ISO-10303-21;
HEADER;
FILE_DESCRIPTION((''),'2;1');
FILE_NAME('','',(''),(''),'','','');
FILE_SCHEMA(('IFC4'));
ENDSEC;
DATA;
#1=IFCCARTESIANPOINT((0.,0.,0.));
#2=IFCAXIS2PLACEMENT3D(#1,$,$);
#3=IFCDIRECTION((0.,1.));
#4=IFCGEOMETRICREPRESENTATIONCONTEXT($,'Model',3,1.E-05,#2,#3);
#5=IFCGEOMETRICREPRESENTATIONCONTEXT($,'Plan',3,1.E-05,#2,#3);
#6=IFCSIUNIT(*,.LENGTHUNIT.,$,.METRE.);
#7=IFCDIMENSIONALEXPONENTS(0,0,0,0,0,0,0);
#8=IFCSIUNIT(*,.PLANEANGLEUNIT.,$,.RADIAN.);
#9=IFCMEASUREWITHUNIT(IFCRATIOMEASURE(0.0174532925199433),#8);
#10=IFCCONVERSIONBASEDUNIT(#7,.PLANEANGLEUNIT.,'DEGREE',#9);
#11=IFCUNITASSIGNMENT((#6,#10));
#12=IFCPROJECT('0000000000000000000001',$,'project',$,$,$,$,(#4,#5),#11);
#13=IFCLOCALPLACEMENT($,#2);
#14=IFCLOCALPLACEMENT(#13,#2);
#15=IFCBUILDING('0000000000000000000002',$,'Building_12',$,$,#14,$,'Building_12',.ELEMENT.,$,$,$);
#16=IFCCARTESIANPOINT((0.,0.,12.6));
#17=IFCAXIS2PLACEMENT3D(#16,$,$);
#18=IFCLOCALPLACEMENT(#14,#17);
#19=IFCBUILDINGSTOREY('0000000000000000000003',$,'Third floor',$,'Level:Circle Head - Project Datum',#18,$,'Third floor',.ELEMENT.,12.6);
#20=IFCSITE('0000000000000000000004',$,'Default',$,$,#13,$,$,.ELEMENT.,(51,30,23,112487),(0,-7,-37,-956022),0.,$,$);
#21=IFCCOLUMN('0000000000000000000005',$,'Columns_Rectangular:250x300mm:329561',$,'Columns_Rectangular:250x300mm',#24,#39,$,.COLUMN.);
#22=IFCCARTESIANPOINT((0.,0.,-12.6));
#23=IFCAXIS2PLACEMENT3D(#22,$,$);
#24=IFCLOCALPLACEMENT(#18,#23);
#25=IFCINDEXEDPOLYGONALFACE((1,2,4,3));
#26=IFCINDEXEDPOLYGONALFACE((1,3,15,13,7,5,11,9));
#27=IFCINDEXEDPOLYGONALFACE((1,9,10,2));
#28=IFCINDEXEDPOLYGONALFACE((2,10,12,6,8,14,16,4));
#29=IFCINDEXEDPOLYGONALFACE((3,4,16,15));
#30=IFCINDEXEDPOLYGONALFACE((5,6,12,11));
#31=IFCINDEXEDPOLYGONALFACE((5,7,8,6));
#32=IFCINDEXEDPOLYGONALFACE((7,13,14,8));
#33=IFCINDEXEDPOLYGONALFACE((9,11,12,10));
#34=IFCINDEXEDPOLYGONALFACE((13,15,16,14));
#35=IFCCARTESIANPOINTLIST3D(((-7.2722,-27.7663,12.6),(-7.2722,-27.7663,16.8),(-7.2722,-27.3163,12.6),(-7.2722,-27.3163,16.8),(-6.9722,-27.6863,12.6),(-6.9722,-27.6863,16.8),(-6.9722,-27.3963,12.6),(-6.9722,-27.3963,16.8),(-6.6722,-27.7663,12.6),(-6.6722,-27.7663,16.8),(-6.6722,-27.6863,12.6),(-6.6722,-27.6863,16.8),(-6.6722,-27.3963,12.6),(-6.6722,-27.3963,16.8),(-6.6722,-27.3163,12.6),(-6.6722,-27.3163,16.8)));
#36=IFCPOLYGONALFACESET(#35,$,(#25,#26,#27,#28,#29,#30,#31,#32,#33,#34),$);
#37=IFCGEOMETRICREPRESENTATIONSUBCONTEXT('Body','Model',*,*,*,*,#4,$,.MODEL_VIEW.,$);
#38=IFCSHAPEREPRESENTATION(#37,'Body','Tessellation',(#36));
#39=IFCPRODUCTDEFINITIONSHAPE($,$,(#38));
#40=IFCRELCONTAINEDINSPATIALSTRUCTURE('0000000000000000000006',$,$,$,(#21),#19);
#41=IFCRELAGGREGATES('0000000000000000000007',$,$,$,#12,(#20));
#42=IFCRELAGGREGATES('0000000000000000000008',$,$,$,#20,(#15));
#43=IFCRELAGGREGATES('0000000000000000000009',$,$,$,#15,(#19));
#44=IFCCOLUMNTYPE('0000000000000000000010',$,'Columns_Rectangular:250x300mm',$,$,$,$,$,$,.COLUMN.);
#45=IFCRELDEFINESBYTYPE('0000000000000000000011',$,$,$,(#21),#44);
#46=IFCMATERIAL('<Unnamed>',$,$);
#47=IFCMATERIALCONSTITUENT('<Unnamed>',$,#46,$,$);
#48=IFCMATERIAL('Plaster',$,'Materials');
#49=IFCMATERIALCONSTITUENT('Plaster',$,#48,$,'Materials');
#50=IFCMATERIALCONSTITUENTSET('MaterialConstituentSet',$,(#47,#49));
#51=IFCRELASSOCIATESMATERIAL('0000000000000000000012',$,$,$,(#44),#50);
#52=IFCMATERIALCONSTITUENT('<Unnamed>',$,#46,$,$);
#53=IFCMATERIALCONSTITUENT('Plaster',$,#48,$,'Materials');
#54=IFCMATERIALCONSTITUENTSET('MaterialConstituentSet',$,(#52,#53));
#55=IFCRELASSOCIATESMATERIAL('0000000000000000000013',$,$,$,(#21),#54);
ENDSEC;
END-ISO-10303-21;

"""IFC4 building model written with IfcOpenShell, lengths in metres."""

from ifc_helpers import new_model, entity, si_unit, converted_unit, direction, frame, origin, place, context, subcontext, project, spatial, indexed_curve, outline, extrude, source, transform, mapped, material, constituent, constituent_set, type_object, type_shapes, element, save


model = new_model("IFC4")

# Units and contexts
model_context = context("Model", 3, precision=1e-05, world=origin(), true_north=direction((0.0, 1.0)))
plan_context = context("Plan", 3, precision=1e-05, world=origin(), true_north=direction((0.0, 1.0)))
body_context = subcontext(model_context, "Body", "Model", "MODEL_VIEW")
ifc_project = project(units=[si_unit("LENGTHUNIT", "METRE"), converted_unit("PLANEANGLEUNIT", "DEGREE", entity("IfcRatioMeasure", 0.0174532925199433), si_unit("PLANEANGLEUNIT", "RADIAN"), dimensions=[0, 0, 0, 0, 0, 0, 0])], contexts=[model_context, plan_context])

# Site, building, storey
site_placement = place(None, origin())
site = spatial("IfcSite", under=ifc_project, at=site_placement, Name="Default", CompositionType="ELEMENT", RefLatitude=(51, 30, 23, 112487), RefLongitude=(0, -7, -37, -956022), RefElevation=0.0)
building_placement = place(site_placement, origin())
building = spatial("IfcBuilding", under=site, at=building_placement, Name="Building_12", LongName="Building_12", CompositionType="ELEMENT")
storey_placement = place(building_placement, frame((0.0, 0.0, 12.6)))
storey = spatial("IfcBuildingStorey", under=building, at=storey_placement, Name="Third floor", ObjectType="Level:Circle Head - Project Datum", LongName="Third floor", CompositionType="ELEMENT", Elevation=12.6)

# Column
ifc_material_1 = material(Name="<Unnamed>")
ifc_constituent_1 = constituent(ifc_material_1, Name="<Unnamed>")
ifc_material_2 = material(Name="Plaster", Category="Materials")
ifc_constituent_2 = constituent(ifc_material_2, Name="Plaster", Category="Materials")
ifc_constituent_set_1 = constituent_set(constituents=[ifc_constituent_1, ifc_constituent_2], Name="MaterialConstituentSet")
ifc_constituent_3 = constituent(ifc_material_1, Name="<Unnamed>")
ifc_constituent_4 = constituent(ifc_material_2, Name="Plaster", Category="Materials")
ifc_constituent_set_2 = constituent_set(constituents=[ifc_constituent_3, ifc_constituent_4], Name="MaterialConstituentSet")
column_type_1 = type_object("IfcColumnType", Name="Columns_Rectangular:250x300mm", PredefinedType="COLUMN", material=ifc_constituent_set_2)
shared_shape_1 = source(origin(), body_context, "Body", "SweptSolid", [
    extrude(outline(indexed_curve([(-0.225, -0.375), (0.225, -0.375), (0.225, 0.225), (0.145, 0.225), (0.145, -0.075), (-0.145, -0.075), (-0.145, 0.225), (-0.225, 0.225), (-0.225, -0.375)], self_intersect=False)), frame((-6.8972, -27.5413, 12.6), z_axis=(0.0, 0.0, 1.0), x_axis=(0.0, -1.0, 0.0)), (0.0, 0.0, 1.0), 4.2),
])
type_shapes(column_type_1, [shared_shape_1])
column_1_placement = place(storey_placement, frame((0.0, 0.0, -12.6)))
element("IfcColumn", 1, at=column_1_placement, inside=storey, type_object=column_type_1, material=ifc_constituent_set_1, Name="Columns_Rectangular:250x300mm:329561", ObjectType="Columns_Rectangular:250x300mm", PredefinedType="COLUMN", context=body_context, shape_type="MappedRepresentation", body=[
    mapped(shared_shape_1, transform((0.0, 0.0, 0.0), scale=1.0)),
])

save(model, "model.ifc")
